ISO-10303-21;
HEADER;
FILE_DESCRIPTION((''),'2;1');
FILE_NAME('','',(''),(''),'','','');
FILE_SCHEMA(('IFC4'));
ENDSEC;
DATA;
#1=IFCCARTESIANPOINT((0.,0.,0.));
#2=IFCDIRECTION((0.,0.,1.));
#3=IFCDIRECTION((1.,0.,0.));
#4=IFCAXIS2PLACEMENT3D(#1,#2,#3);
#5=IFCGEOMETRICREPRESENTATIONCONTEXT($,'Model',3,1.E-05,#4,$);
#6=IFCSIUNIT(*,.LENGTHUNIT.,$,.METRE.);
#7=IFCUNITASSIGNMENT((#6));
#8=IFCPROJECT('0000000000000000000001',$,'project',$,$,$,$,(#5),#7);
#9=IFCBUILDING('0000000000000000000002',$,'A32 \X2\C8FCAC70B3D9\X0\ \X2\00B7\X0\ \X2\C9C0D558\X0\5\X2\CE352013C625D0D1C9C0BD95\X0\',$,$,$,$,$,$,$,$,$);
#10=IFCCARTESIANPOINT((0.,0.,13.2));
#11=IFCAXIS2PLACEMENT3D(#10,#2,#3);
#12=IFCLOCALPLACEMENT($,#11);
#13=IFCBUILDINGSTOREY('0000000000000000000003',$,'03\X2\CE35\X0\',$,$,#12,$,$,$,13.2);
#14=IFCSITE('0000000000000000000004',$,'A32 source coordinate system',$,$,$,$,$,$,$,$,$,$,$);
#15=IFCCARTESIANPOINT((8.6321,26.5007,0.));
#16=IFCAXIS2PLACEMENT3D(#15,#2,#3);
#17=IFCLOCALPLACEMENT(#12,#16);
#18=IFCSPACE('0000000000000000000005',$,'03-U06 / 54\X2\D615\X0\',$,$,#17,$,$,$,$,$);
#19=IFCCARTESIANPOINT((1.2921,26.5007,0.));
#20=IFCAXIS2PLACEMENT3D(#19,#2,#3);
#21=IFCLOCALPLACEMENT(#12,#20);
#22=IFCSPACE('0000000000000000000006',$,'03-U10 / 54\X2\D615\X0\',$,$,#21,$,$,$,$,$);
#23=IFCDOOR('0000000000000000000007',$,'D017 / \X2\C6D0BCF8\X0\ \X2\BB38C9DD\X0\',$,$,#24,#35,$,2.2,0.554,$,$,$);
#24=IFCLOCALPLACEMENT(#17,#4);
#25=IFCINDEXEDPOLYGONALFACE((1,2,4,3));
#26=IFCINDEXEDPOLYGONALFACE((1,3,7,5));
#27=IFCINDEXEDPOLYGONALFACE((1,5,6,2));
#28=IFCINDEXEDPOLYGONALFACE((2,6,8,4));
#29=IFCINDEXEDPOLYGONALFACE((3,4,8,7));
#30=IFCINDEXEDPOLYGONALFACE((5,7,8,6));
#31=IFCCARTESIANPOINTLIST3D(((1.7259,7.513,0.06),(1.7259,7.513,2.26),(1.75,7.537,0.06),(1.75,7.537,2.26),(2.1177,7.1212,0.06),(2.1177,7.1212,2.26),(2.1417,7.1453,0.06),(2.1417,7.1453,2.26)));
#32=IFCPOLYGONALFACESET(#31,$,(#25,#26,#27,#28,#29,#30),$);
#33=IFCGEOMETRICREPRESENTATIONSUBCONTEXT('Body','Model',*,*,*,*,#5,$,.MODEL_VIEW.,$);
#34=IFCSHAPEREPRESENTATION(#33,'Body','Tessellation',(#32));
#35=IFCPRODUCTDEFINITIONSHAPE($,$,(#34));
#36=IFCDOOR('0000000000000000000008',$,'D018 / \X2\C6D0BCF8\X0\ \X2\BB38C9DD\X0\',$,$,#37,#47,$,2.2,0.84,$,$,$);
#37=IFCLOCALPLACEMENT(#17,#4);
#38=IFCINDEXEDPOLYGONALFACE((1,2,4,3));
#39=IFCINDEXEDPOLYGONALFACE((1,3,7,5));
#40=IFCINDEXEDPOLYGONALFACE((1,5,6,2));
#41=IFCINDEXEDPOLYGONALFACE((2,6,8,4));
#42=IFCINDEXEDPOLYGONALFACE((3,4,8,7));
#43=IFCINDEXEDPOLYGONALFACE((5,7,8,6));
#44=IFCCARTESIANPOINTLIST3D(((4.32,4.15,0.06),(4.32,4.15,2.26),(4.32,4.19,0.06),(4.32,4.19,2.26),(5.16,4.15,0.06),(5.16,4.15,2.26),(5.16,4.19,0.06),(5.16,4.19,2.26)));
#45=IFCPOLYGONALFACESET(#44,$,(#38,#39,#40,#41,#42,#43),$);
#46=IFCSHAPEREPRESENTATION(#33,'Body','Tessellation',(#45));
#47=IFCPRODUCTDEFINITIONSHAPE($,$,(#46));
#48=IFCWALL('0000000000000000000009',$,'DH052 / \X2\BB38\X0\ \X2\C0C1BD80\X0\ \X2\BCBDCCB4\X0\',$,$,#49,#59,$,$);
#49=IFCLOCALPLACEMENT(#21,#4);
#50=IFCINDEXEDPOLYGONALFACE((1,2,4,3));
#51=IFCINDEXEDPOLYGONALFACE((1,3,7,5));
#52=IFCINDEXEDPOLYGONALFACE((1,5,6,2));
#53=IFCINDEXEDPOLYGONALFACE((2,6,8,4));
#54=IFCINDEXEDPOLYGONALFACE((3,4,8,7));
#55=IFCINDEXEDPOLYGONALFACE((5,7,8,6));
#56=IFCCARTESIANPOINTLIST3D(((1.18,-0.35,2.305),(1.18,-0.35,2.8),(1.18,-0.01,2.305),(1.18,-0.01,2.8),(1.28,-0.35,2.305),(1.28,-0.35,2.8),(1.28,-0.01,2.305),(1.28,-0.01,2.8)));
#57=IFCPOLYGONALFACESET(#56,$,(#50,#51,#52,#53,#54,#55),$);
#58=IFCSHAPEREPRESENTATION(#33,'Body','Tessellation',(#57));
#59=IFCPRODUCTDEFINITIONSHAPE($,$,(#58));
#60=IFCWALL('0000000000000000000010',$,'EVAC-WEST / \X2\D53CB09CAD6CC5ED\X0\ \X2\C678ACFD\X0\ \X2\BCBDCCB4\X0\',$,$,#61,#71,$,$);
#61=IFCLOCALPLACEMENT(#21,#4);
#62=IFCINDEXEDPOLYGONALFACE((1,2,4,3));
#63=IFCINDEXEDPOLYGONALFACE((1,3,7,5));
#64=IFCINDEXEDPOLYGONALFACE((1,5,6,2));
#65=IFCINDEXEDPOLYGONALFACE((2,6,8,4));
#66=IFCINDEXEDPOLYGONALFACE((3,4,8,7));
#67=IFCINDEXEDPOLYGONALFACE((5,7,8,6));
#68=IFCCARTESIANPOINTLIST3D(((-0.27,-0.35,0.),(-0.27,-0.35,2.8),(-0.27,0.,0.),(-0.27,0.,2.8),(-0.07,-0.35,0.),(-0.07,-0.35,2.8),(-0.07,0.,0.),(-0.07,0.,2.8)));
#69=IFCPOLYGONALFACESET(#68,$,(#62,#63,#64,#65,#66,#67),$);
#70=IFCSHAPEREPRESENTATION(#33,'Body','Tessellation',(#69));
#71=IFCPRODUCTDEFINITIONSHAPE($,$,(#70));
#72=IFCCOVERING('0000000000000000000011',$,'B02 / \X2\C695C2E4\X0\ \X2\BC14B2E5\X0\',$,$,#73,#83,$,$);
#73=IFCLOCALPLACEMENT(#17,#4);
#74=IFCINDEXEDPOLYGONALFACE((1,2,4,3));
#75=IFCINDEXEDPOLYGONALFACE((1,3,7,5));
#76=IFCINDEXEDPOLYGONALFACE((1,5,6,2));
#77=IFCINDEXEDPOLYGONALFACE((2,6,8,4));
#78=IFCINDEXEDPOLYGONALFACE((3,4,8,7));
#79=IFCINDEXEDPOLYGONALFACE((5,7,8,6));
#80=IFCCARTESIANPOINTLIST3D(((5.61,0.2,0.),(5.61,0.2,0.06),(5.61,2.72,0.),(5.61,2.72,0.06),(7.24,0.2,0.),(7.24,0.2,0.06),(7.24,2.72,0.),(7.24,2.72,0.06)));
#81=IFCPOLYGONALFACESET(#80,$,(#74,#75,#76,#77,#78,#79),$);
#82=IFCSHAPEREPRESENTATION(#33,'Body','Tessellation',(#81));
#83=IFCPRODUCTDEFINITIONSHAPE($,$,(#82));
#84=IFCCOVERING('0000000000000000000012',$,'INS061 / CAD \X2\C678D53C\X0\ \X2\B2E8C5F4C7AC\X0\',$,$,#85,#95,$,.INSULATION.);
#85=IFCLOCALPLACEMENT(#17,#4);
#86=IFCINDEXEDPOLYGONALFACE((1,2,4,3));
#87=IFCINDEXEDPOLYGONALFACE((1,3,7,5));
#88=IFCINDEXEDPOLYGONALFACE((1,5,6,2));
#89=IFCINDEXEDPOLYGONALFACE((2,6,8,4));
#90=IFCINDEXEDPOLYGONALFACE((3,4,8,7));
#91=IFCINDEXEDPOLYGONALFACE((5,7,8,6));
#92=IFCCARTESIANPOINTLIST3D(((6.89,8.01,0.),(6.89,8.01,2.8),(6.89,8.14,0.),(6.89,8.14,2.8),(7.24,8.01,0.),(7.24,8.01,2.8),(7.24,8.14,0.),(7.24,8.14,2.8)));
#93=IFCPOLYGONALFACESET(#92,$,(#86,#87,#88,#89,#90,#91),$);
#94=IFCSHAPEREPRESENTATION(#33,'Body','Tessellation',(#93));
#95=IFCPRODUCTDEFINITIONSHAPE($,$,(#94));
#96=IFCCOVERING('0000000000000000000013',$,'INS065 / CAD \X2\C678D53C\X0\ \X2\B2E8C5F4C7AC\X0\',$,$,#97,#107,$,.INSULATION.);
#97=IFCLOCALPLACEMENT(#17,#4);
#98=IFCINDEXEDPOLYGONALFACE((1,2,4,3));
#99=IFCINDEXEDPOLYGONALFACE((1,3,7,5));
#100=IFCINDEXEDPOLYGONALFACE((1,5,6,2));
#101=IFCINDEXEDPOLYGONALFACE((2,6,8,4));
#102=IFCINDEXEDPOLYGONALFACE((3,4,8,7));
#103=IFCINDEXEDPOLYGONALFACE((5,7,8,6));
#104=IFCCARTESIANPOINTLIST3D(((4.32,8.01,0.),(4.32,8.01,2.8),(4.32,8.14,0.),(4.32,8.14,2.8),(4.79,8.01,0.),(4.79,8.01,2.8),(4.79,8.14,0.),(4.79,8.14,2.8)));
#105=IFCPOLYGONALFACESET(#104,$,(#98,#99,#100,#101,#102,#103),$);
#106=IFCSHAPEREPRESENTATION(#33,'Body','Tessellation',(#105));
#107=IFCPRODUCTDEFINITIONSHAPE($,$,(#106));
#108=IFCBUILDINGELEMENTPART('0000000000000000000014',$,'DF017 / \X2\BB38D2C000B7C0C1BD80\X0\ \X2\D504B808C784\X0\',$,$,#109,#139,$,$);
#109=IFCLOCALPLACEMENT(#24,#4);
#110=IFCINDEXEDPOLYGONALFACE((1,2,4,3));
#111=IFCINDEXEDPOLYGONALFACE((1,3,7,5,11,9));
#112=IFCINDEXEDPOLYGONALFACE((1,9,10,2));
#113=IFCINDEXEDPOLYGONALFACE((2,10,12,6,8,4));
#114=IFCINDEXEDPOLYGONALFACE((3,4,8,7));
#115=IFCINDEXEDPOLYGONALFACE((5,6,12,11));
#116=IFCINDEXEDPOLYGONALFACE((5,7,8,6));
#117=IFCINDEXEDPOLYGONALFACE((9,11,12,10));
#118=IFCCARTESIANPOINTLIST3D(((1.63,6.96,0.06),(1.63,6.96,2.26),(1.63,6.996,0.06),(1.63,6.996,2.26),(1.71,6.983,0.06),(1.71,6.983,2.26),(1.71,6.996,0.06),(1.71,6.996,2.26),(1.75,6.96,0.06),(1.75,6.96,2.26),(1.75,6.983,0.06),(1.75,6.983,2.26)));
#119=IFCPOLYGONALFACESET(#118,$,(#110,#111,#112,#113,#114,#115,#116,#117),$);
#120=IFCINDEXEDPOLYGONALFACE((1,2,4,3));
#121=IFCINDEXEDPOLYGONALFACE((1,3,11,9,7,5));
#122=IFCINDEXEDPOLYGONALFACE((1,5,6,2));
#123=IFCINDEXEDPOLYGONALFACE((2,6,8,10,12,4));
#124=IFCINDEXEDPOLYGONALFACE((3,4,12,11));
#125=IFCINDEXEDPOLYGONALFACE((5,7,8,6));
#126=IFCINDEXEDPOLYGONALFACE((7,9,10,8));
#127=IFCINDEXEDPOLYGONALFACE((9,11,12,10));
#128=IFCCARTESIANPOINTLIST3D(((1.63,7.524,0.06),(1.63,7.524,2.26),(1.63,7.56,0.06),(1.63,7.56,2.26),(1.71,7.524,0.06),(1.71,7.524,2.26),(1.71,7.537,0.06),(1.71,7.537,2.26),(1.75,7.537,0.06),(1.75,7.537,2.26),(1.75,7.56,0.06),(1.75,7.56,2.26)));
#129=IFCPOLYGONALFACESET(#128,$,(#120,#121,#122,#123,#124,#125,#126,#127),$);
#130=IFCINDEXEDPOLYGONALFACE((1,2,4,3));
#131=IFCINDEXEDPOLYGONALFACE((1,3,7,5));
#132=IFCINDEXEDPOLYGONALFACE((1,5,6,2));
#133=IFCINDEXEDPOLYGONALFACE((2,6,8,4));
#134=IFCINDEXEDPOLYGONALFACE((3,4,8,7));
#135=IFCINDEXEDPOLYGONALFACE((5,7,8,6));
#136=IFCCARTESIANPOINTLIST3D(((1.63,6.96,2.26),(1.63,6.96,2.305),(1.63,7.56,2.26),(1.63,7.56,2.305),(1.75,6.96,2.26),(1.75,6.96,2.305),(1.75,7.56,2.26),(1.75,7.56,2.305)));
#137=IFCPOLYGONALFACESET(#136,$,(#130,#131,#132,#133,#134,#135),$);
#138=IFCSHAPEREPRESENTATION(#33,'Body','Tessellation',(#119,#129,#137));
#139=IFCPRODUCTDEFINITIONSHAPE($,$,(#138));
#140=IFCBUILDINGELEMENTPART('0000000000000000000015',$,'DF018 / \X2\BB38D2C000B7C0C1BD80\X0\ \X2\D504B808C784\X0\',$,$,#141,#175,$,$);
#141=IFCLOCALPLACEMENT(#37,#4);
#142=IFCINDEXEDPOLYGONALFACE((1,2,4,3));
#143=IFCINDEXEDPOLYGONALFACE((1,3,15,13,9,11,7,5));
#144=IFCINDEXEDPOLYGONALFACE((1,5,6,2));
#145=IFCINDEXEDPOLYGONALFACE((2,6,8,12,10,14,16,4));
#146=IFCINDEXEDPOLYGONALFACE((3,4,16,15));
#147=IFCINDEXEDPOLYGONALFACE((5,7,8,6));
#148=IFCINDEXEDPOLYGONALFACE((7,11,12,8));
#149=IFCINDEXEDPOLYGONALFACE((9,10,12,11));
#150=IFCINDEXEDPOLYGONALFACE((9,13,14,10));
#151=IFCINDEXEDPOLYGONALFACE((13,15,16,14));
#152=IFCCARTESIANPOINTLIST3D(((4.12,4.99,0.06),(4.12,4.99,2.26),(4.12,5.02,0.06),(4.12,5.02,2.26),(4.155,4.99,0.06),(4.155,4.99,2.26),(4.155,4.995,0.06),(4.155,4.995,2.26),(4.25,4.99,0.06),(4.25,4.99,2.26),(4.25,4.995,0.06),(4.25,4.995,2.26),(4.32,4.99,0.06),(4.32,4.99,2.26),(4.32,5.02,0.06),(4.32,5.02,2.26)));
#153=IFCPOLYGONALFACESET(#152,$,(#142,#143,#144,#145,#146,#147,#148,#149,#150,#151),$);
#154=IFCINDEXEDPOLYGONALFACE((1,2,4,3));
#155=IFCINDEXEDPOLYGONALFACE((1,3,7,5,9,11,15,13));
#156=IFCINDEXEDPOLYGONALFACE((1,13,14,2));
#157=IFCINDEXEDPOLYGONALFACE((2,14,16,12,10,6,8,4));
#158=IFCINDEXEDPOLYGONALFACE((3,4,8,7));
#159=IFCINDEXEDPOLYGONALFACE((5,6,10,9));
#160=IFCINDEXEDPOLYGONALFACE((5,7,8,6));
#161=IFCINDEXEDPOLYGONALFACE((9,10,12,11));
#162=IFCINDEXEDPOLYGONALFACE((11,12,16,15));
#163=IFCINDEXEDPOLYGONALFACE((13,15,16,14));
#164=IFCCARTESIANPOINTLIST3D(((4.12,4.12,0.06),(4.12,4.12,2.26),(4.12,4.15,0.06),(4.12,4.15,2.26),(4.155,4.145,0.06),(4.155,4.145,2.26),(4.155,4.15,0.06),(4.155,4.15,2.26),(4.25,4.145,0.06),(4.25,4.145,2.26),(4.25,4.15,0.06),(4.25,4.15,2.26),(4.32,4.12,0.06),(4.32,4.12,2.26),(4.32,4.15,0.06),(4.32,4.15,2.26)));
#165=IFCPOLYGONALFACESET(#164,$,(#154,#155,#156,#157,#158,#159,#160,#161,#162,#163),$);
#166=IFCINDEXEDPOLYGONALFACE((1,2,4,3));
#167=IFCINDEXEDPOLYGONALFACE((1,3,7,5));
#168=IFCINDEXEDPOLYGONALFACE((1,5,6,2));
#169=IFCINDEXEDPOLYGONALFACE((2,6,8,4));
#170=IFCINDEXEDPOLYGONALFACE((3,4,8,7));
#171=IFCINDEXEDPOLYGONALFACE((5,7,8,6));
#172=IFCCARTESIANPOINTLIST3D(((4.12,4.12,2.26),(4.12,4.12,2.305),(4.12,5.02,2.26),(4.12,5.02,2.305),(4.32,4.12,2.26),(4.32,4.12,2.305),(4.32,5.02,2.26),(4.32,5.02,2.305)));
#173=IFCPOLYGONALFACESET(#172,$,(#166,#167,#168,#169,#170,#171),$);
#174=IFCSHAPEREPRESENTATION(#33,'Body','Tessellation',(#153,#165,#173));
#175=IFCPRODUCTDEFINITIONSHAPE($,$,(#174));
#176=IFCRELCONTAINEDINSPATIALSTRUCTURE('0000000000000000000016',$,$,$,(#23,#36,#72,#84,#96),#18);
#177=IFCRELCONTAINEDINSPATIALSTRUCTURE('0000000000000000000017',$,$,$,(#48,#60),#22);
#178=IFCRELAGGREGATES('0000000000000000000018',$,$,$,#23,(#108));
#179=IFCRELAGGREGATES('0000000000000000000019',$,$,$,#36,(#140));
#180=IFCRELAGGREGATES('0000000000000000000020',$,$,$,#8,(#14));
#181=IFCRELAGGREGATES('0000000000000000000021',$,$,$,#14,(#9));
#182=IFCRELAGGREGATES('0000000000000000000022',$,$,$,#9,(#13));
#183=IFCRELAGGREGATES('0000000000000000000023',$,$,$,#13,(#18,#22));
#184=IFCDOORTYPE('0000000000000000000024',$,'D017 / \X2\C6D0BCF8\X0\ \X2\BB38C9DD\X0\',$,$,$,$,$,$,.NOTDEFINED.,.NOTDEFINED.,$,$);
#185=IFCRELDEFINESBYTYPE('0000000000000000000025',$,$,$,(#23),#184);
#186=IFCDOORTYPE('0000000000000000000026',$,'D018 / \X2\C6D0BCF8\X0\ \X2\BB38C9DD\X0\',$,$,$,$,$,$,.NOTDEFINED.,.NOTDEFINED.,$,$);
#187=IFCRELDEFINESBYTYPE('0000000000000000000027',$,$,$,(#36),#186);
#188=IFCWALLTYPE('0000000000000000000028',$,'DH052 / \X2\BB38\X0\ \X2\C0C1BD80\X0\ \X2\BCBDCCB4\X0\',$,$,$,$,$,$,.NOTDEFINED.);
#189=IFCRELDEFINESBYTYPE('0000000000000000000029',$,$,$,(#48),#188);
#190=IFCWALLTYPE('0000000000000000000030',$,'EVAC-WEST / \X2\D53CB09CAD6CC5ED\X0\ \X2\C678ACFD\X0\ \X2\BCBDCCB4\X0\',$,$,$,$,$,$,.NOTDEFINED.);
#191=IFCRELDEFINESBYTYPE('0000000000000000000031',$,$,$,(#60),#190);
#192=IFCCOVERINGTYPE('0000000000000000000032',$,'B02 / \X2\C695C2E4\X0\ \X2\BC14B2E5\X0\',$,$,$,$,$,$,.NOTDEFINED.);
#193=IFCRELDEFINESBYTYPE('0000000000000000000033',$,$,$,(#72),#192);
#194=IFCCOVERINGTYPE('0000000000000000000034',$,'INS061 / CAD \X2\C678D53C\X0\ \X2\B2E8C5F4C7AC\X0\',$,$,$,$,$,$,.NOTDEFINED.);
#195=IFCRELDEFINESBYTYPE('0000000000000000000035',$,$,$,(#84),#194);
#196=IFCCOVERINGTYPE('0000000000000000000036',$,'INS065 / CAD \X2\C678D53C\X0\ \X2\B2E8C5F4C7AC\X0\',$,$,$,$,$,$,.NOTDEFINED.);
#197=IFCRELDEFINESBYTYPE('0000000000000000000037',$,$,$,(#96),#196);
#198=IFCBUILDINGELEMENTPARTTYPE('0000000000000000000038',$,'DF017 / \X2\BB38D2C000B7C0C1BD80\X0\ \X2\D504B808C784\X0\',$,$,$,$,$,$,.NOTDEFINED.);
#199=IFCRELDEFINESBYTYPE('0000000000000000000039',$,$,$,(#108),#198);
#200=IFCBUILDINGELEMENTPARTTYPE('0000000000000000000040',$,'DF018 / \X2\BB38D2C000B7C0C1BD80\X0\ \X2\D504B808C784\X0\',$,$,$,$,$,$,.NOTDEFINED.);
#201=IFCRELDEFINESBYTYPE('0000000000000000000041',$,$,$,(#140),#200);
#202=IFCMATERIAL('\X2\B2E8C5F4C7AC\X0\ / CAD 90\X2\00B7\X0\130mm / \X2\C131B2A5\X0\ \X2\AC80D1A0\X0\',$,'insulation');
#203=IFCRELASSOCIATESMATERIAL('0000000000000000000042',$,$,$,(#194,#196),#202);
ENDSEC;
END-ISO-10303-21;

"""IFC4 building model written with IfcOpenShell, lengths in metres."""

from ifc_helpers import new_model, si_unit, frame, origin, origin_with_axes, place, context, subcontext, project, spatial, polyline, outline, extrude, source, transform, mapped, material, type_object, type_shapes, element, aggregate, save


model = new_model("IFC4")

# Units and contexts
model_context = context("Model", 3, precision=1e-05, world=origin_with_axes())
body_context = subcontext(model_context, "Body", "Model", "MODEL_VIEW")
ifc_project = project(units=[si_unit("LENGTHUNIT", "METRE")], contexts=[model_context])

# Site, building, storey, space
storey_placement = place(None, frame((0.0, 0.0, 13.2), z_axis=(0.0, 0.0, 1.0), x_axis=(1.0, 0.0, 0.0)))
space_1_placement = place(storey_placement, frame((8.6321, 26.5007, 0.0), z_axis=(0.0, 0.0, 1.0), x_axis=(1.0, 0.0, 0.0)))
site = spatial("IfcSite", under=ifc_project, Name="A32 source coordinate system")
building = spatial("IfcBuilding", under=site, Name="A32 주거동 · 지하5층–옥탑지붕")
storey = spatial("IfcBuildingStorey", under=building, at=storey_placement, Name="03층", Elevation=13.2)
space_1 = spatial("IfcSpace", under=storey, at=space_1_placement, Name="03-U06 / 54형")

# Doors
door_type_1 = type_object("IfcDoorType", Name="D017 / 원본 문짝", OperationType="NOTDEFINED", PredefinedType="NOTDEFINED")
shared_shape_1 = source(origin(), body_context, "Body", "SweptSolid", [
    extrude(outline(polyline([(1.75, 7.537), (2.1417, 7.1453), (2.1177, 7.1212), (1.7259, 7.513), (1.75, 7.537)])), frame((0.0, 0.0, 0.06)), (0.0, 0.0, 1.0), 2.2),
])
type_shapes(door_type_1, [shared_shape_1])
door_1_placement = place(space_1_placement, origin_with_axes())
door_1 = element("IfcDoor", 1, at=door_1_placement, inside=space_1, type_object=door_type_1, Name="D017 / 원본 문짝", OverallHeight=2.2, OverallWidth=0.554, context=body_context, shape_type="MappedRepresentation", body=[
    mapped(shared_shape_1, transform((0.0, 0.0, 0.0), scale=1.0)),
])
door_type_2 = type_object("IfcDoorType", Name="D018 / 원본 문짝", OperationType="NOTDEFINED", PredefinedType="NOTDEFINED")
shared_shape_2 = source(origin(), body_context, "Body", "SweptSolid", [
    extrude(outline(polyline([(5.16, 4.19), (5.16, 4.15), (4.32, 4.15), (4.32, 4.19), (5.16, 4.19)])), frame((0.0, 0.0, 0.06)), (0.0, 0.0, 1.0), 2.2),
])
type_shapes(door_type_2, [shared_shape_2])
door_2_placement = place(space_1_placement, origin_with_axes())
door_2 = element("IfcDoor", 2, at=door_2_placement, inside=space_1, type_object=door_type_2, Name="D018 / 원본 문짝", OverallHeight=2.2, OverallWidth=0.84, context=body_context, shape_type="MappedRepresentation", body=[
    mapped(shared_shape_2, transform((0.0, 0.0, 0.0), scale=1.0)),
])

# Shared definitions
space_2_placement = place(storey_placement, frame((1.2921, 26.5007, 0.0), z_axis=(0.0, 0.0, 1.0), x_axis=(1.0, 0.0, 0.0)))
space_2 = spatial("IfcSpace", under=storey, at=space_2_placement, Name="03-U10 / 54형")

# Walls
wall_type_1 = type_object("IfcWallType", Name="DH052 / 문 상부 벽체", PredefinedType="NOTDEFINED")
shared_shape_3 = source(origin(), body_context, "Body", "SweptSolid", [
    extrude(outline(polyline([(1.28, -0.35), (1.18, -0.35), (1.18, -0.01), (1.28, -0.01), (1.28, -0.35)])), frame((0.0, 0.0, 2.305)), (0.0, 0.0, 1.0), 0.495),
])
type_shapes(wall_type_1, [shared_shape_3])
wall_1_placement = place(space_2_placement, origin_with_axes())
element("IfcWall", 3, at=wall_1_placement, inside=space_2, type_object=wall_type_1, Name="DH052 / 문 상부 벽체", context=body_context, shape_type="MappedRepresentation", body=[
    mapped(shared_shape_3, transform((0.0, 0.0, 0.0), scale=1.0)),
])
wall_type_2 = type_object("IfcWallType", Name="EVAC-WEST / 피난구역 외곽 벽체", PredefinedType="NOTDEFINED")
shared_shape_4 = source(origin(), body_context, "Body", "SweptSolid", [
    extrude(outline(polyline([(-0.07, 0.0), (-0.07, -0.35), (-0.27, -0.35), (-0.27, 0.0), (-0.07, 0.0)])), origin(), (0.0, 0.0, 1.0), 2.8),
])
type_shapes(wall_type_2, [shared_shape_4])
wall_2_placement = place(space_2_placement, origin_with_axes())
element("IfcWall", 4, at=wall_2_placement, inside=space_2, type_object=wall_type_2, Name="EVAC-WEST / 피난구역 외곽 벽체", context=body_context, shape_type="MappedRepresentation", body=[
    mapped(shared_shape_4, transform((0.0, 0.0, 0.0), scale=1.0)),
])

# Coverings
covering_type_1 = type_object("IfcCoveringType", Name="B02 / 욕실 바닥", PredefinedType="NOTDEFINED")
shared_shape_5 = source(origin(), body_context, "Body", "SweptSolid", [
    extrude(outline(polyline([(5.61, 2.72), (7.24, 2.72), (7.24, 0.2), (5.61, 0.2), (5.61, 2.72)])), origin(), (0.0, 0.0, 1.0), 0.06),
])
type_shapes(covering_type_1, [shared_shape_5])
covering_1_placement = place(space_1_placement, origin_with_axes())
element("IfcCovering", 5, at=covering_1_placement, inside=space_1, type_object=covering_type_1, Name="B02 / 욕실 바닥", context=body_context, shape_type="MappedRepresentation", body=[
    mapped(shared_shape_5, transform((0.0, 0.0, 0.0), scale=1.0)),
])
ifc_material = material(Name="단열재 / CAD 90·130mm / 성능 검토", Category="insulation")
covering_type_2 = type_object("IfcCoveringType", Name="INS061 / CAD 외피 단열재", PredefinedType="NOTDEFINED", material=ifc_material)
shared_shape_6 = source(origin(), body_context, "Body", "SweptSolid", [
    extrude(outline(polyline([(6.89, 8.01), (6.89, 8.14), (7.24, 8.14), (7.24, 8.01), (6.89, 8.01)])), origin(), (0.0, 0.0, 1.0), 2.8),
])
type_shapes(covering_type_2, [shared_shape_6])
covering_2_placement = place(space_1_placement, origin_with_axes())
element("IfcCovering", 6, at=covering_2_placement, inside=space_1, type_object=covering_type_2, Name="INS061 / CAD 외피 단열재", PredefinedType="INSULATION", context=body_context, shape_type="MappedRepresentation", body=[
    mapped(shared_shape_6, transform((0.0, 0.0, 0.0), scale=1.0)),
])
covering_type_3 = type_object("IfcCoveringType", Name="INS065 / CAD 외피 단열재", PredefinedType="NOTDEFINED", material=ifc_material)
shared_shape_7 = source(origin(), body_context, "Body", "SweptSolid", [
    extrude(outline(polyline([(4.32, 8.01), (4.32, 8.14), (4.79, 8.14), (4.79, 8.01), (4.32, 8.01)])), origin(), (0.0, 0.0, 1.0), 2.8),
])
type_shapes(covering_type_3, [shared_shape_7])
covering_3_placement = place(space_1_placement, origin_with_axes())
element("IfcCovering", 7, at=covering_3_placement, inside=space_1, type_object=covering_type_3, Name="INS065 / CAD 외피 단열재", PredefinedType="INSULATION", context=body_context, shape_type="MappedRepresentation", body=[
    mapped(shared_shape_7, transform((0.0, 0.0, 0.0), scale=1.0)),
])

# Building element parts
building_element_part_type_1 = type_object("IfcBuildingElementPartType", Name="DF017 / 문틀·상부 프레임", PredefinedType="NOTDEFINED")
shared_shape_8 = source(origin(), body_context, "Body", "SweptSolid", [
    extrude(outline(polyline([(1.63, 6.996), (1.71, 6.996), (1.71, 6.983), (1.75, 6.983), (1.75, 6.96), (1.63, 6.96), (1.63, 6.996)])), frame((0.0, 0.0, 0.06)), (0.0, 0.0, 1.0), 2.2),
    extrude(outline(polyline([(1.75, 7.56), (1.75, 7.537), (1.71, 7.537), (1.71, 7.524), (1.63, 7.524), (1.63, 7.56), (1.75, 7.56)])), frame((0.0, 0.0, 0.06)), (0.0, 0.0, 1.0), 2.2),
    extrude(outline(polyline([(1.63, 6.96), (1.63, 7.56), (1.75, 7.56), (1.75, 6.96), (1.63, 6.96)])), frame((0.0, 0.0, 2.26)), (0.0, 0.0, 1.0), 0.045),
])
type_shapes(building_element_part_type_1, [shared_shape_8])
building_element_part_1_placement = place(door_1_placement, origin_with_axes())
building_element_part_1 = element("IfcBuildingElementPart", 8, at=building_element_part_1_placement, type_object=building_element_part_type_1, Name="DF017 / 문틀·상부 프레임", context=body_context, shape_type="MappedRepresentation", body=[
    mapped(shared_shape_8, transform((0.0, 0.0, 0.0), scale=1.0)),
])
aggregate(door_1, [building_element_part_1])
building_element_part_type_2 = type_object("IfcBuildingElementPartType", Name="DF018 / 문틀·상부 프레임", PredefinedType="NOTDEFINED")
shared_shape_9 = source(origin(), body_context, "Body", "SweptSolid", [
    extrude(outline(polyline([(4.32, 4.99), (4.25, 4.99), (4.25, 4.995), (4.155, 4.995), (4.155, 4.99), (4.12, 4.99), (4.12, 5.02), (4.32, 5.02), (4.32, 4.99)])), frame((0.0, 0.0, 0.06)), (0.0, 0.0, 1.0), 2.2),
    extrude(outline(polyline([(4.12, 4.12), (4.12, 4.15), (4.155, 4.15), (4.155, 4.145), (4.25, 4.145), (4.25, 4.15), (4.32, 4.15), (4.32, 4.12), (4.12, 4.12)])), frame((0.0, 0.0, 0.06)), (0.0, 0.0, 1.0), 2.2),
    extrude(outline(polyline([(4.12, 4.12), (4.12, 5.02), (4.32, 5.02), (4.32, 4.12), (4.12, 4.12)])), frame((0.0, 0.0, 2.26)), (0.0, 0.0, 1.0), 0.045),
])
type_shapes(building_element_part_type_2, [shared_shape_9])
building_element_part_2_placement = place(door_2_placement, origin_with_axes())
building_element_part_2 = element("IfcBuildingElementPart", 9, at=building_element_part_2_placement, type_object=building_element_part_type_2, Name="DF018 / 문틀·상부 프레임", context=body_context, shape_type="MappedRepresentation", body=[
    mapped(shared_shape_9, transform((0.0, 0.0, 0.0), scale=1.0)),
])
aggregate(door_2, [building_element_part_2])

save(model, "model.ifc")
